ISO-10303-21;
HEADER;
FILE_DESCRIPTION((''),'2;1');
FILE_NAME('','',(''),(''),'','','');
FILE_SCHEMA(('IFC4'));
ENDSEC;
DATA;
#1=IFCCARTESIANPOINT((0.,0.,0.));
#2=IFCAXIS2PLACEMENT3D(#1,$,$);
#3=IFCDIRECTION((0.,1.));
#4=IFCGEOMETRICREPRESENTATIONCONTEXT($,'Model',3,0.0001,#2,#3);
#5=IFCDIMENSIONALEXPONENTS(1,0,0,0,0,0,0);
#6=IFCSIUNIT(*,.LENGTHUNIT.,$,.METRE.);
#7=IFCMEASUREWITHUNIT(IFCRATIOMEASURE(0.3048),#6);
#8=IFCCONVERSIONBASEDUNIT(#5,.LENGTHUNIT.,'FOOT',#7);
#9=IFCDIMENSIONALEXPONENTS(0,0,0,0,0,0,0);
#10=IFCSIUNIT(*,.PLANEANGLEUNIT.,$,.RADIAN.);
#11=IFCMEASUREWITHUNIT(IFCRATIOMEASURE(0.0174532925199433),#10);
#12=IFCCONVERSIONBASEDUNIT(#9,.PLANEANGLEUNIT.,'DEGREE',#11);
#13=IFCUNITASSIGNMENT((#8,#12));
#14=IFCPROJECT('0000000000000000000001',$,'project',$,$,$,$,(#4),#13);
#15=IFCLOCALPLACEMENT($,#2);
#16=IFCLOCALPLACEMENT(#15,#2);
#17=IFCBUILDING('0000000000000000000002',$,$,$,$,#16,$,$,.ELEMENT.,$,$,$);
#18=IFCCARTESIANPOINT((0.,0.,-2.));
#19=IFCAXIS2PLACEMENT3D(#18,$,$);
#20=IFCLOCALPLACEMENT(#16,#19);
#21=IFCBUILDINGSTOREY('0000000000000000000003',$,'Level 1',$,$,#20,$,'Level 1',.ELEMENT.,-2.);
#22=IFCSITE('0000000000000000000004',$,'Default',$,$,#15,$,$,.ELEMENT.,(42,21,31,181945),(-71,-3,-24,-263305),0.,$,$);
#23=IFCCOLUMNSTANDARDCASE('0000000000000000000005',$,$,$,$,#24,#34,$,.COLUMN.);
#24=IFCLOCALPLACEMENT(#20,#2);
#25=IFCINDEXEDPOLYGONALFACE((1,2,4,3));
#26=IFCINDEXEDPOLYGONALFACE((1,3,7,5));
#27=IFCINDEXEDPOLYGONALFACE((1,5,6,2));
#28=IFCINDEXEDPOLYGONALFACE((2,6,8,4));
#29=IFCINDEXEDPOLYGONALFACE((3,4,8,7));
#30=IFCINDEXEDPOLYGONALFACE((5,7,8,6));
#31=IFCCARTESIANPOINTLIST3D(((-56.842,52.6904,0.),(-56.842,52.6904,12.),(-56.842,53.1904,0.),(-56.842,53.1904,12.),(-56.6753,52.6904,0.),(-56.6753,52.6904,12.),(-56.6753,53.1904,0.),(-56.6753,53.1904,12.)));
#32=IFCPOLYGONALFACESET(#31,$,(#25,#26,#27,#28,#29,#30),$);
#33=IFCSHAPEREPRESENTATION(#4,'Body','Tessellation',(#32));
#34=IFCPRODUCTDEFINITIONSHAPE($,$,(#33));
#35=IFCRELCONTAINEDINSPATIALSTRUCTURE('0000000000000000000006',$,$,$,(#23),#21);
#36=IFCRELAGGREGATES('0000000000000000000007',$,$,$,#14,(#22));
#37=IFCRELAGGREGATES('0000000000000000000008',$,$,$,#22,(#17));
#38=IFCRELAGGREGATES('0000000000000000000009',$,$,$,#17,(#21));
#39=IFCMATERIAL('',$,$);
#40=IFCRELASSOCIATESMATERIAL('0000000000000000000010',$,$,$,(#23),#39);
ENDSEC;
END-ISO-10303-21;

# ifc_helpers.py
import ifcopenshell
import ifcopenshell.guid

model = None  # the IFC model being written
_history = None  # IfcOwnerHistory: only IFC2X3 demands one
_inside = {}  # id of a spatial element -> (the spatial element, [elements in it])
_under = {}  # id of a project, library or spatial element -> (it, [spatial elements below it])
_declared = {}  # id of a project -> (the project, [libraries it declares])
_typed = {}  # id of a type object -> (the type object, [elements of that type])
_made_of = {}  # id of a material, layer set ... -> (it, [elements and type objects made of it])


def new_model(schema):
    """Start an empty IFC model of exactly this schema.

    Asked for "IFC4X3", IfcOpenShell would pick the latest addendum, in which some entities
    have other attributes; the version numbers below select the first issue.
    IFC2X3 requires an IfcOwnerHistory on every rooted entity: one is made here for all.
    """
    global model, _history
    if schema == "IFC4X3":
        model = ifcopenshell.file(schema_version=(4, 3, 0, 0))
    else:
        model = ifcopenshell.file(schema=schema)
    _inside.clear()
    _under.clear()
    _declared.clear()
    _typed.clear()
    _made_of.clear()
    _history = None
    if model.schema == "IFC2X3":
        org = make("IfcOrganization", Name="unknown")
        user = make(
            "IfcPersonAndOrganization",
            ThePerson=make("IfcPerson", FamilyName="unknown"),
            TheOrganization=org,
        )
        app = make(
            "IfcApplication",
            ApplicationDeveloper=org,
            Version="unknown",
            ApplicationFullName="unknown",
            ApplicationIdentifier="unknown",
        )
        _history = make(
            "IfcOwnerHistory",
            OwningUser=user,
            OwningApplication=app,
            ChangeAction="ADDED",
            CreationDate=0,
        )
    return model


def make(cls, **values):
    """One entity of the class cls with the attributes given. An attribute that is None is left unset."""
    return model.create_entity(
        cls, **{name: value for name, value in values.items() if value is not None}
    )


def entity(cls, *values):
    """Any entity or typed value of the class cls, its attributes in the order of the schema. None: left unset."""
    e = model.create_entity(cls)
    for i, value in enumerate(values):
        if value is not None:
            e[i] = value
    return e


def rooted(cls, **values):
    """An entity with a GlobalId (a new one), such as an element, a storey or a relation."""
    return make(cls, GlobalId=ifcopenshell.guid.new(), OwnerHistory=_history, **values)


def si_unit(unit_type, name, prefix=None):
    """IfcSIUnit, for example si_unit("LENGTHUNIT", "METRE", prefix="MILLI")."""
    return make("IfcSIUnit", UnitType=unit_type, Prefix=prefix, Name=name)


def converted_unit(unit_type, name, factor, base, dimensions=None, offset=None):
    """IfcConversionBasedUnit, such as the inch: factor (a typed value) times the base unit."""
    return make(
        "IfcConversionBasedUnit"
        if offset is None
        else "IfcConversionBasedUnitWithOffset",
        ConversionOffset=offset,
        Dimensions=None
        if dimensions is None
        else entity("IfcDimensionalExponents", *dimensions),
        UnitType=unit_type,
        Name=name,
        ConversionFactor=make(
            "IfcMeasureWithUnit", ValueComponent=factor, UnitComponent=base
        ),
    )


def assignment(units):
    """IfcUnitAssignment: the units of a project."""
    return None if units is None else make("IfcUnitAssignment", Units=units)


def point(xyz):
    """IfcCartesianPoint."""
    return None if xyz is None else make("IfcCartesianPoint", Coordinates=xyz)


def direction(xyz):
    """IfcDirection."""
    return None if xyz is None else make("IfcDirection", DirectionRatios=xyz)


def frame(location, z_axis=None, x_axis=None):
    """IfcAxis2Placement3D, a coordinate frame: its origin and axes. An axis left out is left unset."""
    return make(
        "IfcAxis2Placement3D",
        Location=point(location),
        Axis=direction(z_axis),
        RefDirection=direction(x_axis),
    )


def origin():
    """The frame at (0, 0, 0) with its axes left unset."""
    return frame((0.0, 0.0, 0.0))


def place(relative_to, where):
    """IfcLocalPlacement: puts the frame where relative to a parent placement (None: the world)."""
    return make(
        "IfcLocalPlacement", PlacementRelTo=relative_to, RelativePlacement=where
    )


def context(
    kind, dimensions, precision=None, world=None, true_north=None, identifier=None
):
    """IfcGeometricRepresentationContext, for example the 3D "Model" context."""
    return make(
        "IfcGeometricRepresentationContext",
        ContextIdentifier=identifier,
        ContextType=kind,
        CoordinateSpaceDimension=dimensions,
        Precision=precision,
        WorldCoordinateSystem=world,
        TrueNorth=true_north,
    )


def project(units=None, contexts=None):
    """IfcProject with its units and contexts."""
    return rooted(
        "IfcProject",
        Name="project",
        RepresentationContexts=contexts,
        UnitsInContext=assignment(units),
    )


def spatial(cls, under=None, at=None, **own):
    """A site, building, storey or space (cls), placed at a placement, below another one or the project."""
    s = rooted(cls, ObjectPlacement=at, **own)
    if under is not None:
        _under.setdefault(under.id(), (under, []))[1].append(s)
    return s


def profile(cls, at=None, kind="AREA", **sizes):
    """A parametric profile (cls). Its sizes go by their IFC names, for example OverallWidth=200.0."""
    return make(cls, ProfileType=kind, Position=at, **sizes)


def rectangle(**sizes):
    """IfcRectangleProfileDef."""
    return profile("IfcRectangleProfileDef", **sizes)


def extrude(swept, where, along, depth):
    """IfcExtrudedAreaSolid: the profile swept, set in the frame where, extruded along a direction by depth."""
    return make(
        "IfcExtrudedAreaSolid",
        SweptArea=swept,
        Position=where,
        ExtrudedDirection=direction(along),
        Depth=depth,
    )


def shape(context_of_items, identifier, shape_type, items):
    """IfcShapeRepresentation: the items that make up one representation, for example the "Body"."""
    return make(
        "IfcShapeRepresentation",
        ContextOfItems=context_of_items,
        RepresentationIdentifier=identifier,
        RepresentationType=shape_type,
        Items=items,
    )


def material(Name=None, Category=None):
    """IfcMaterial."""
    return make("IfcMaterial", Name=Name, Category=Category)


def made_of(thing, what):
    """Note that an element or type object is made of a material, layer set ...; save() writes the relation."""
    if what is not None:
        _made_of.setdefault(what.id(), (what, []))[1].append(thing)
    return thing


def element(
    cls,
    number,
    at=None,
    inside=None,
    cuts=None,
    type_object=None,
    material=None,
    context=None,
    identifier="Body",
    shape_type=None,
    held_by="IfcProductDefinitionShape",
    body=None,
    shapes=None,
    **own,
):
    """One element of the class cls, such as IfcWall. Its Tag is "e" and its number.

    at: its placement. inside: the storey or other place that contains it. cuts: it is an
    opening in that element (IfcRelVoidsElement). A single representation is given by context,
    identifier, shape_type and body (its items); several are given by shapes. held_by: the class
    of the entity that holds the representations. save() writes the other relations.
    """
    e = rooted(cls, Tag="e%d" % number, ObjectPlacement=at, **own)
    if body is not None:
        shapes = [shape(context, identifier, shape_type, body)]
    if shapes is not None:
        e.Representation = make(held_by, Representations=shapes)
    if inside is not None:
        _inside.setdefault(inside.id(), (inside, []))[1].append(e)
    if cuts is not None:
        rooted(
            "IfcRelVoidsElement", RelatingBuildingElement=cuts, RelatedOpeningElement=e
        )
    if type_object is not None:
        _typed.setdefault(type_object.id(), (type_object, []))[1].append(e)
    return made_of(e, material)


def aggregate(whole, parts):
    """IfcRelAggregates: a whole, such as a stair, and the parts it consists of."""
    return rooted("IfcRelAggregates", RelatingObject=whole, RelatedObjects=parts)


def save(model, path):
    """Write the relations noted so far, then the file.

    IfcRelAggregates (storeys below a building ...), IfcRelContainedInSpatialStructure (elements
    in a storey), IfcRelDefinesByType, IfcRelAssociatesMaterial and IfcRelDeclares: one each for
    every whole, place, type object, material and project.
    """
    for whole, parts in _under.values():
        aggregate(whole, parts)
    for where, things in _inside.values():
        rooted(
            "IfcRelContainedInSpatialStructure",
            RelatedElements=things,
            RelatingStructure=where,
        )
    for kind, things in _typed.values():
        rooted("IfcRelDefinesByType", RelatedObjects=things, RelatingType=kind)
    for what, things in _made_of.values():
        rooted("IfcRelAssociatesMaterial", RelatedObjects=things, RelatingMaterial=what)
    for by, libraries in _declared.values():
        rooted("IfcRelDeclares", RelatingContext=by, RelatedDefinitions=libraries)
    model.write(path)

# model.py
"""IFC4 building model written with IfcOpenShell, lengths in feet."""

from ifc_helpers import new_model, entity, si_unit, converted_unit, direction, frame, origin, place, context, project, spatial, rectangle, extrude, material, element, save


model = new_model("IFC4")

# Units and contexts
model_context = context("Model", 3, precision=0.0001, world=origin(), true_north=direction((0.0, 1.0)))
ifc_project = project(units=[converted_unit("LENGTHUNIT", "FOOT", entity("IfcRatioMeasure", 0.3048), si_unit("LENGTHUNIT", "METRE"), dimensions=[1, 0, 0, 0, 0, 0, 0]), converted_unit("PLANEANGLEUNIT", "DEGREE", entity("IfcRatioMeasure", 0.0174532925199433), si_unit("PLANEANGLEUNIT", "RADIAN"), dimensions=[0, 0, 0, 0, 0, 0, 0])], contexts=[model_context])

# Site, building, storey
site_placement = place(None, origin())
site = spatial("IfcSite", under=ifc_project, at=site_placement, Name="Default", CompositionType="ELEMENT", RefLatitude=(42, 21, 31, 181945), RefLongitude=(-71, -3, -24, -263305), RefElevation=0.0)
building_placement = place(site_placement, origin())
building = spatial("IfcBuilding", under=site, at=building_placement, CompositionType="ELEMENT")
storey_placement = place(building_placement, frame((0.0, 0.0, -2.0)))
storey = spatial("IfcBuildingStorey", under=building, at=storey_placement, Name="Level 1", LongName="Level 1", CompositionType="ELEMENT", Elevation=-2.0)

# Column
ifc_material_1 = material(Name="")
wall_placement = place(storey_placement, frame((-56.842, 52.9404, 0.0)))
column_placement = place(wall_placement, frame((0.0833, 0.0, 0.0), z_axis=(0.0, 0.0, 1.0), x_axis=(1.0, 0.0, 0.0)))
element("IfcColumnStandardCase", 1, at=column_placement, inside=storey, material=ifc_material_1, PredefinedType="COLUMN", context=model_context, shape_type="SweptSolid", body=[
    extrude(rectangle(XDim=0.1667, YDim=0.5), origin(), (0.0, 0.0, 1.0), 12.0),
])

save(model, "model.ifc")
